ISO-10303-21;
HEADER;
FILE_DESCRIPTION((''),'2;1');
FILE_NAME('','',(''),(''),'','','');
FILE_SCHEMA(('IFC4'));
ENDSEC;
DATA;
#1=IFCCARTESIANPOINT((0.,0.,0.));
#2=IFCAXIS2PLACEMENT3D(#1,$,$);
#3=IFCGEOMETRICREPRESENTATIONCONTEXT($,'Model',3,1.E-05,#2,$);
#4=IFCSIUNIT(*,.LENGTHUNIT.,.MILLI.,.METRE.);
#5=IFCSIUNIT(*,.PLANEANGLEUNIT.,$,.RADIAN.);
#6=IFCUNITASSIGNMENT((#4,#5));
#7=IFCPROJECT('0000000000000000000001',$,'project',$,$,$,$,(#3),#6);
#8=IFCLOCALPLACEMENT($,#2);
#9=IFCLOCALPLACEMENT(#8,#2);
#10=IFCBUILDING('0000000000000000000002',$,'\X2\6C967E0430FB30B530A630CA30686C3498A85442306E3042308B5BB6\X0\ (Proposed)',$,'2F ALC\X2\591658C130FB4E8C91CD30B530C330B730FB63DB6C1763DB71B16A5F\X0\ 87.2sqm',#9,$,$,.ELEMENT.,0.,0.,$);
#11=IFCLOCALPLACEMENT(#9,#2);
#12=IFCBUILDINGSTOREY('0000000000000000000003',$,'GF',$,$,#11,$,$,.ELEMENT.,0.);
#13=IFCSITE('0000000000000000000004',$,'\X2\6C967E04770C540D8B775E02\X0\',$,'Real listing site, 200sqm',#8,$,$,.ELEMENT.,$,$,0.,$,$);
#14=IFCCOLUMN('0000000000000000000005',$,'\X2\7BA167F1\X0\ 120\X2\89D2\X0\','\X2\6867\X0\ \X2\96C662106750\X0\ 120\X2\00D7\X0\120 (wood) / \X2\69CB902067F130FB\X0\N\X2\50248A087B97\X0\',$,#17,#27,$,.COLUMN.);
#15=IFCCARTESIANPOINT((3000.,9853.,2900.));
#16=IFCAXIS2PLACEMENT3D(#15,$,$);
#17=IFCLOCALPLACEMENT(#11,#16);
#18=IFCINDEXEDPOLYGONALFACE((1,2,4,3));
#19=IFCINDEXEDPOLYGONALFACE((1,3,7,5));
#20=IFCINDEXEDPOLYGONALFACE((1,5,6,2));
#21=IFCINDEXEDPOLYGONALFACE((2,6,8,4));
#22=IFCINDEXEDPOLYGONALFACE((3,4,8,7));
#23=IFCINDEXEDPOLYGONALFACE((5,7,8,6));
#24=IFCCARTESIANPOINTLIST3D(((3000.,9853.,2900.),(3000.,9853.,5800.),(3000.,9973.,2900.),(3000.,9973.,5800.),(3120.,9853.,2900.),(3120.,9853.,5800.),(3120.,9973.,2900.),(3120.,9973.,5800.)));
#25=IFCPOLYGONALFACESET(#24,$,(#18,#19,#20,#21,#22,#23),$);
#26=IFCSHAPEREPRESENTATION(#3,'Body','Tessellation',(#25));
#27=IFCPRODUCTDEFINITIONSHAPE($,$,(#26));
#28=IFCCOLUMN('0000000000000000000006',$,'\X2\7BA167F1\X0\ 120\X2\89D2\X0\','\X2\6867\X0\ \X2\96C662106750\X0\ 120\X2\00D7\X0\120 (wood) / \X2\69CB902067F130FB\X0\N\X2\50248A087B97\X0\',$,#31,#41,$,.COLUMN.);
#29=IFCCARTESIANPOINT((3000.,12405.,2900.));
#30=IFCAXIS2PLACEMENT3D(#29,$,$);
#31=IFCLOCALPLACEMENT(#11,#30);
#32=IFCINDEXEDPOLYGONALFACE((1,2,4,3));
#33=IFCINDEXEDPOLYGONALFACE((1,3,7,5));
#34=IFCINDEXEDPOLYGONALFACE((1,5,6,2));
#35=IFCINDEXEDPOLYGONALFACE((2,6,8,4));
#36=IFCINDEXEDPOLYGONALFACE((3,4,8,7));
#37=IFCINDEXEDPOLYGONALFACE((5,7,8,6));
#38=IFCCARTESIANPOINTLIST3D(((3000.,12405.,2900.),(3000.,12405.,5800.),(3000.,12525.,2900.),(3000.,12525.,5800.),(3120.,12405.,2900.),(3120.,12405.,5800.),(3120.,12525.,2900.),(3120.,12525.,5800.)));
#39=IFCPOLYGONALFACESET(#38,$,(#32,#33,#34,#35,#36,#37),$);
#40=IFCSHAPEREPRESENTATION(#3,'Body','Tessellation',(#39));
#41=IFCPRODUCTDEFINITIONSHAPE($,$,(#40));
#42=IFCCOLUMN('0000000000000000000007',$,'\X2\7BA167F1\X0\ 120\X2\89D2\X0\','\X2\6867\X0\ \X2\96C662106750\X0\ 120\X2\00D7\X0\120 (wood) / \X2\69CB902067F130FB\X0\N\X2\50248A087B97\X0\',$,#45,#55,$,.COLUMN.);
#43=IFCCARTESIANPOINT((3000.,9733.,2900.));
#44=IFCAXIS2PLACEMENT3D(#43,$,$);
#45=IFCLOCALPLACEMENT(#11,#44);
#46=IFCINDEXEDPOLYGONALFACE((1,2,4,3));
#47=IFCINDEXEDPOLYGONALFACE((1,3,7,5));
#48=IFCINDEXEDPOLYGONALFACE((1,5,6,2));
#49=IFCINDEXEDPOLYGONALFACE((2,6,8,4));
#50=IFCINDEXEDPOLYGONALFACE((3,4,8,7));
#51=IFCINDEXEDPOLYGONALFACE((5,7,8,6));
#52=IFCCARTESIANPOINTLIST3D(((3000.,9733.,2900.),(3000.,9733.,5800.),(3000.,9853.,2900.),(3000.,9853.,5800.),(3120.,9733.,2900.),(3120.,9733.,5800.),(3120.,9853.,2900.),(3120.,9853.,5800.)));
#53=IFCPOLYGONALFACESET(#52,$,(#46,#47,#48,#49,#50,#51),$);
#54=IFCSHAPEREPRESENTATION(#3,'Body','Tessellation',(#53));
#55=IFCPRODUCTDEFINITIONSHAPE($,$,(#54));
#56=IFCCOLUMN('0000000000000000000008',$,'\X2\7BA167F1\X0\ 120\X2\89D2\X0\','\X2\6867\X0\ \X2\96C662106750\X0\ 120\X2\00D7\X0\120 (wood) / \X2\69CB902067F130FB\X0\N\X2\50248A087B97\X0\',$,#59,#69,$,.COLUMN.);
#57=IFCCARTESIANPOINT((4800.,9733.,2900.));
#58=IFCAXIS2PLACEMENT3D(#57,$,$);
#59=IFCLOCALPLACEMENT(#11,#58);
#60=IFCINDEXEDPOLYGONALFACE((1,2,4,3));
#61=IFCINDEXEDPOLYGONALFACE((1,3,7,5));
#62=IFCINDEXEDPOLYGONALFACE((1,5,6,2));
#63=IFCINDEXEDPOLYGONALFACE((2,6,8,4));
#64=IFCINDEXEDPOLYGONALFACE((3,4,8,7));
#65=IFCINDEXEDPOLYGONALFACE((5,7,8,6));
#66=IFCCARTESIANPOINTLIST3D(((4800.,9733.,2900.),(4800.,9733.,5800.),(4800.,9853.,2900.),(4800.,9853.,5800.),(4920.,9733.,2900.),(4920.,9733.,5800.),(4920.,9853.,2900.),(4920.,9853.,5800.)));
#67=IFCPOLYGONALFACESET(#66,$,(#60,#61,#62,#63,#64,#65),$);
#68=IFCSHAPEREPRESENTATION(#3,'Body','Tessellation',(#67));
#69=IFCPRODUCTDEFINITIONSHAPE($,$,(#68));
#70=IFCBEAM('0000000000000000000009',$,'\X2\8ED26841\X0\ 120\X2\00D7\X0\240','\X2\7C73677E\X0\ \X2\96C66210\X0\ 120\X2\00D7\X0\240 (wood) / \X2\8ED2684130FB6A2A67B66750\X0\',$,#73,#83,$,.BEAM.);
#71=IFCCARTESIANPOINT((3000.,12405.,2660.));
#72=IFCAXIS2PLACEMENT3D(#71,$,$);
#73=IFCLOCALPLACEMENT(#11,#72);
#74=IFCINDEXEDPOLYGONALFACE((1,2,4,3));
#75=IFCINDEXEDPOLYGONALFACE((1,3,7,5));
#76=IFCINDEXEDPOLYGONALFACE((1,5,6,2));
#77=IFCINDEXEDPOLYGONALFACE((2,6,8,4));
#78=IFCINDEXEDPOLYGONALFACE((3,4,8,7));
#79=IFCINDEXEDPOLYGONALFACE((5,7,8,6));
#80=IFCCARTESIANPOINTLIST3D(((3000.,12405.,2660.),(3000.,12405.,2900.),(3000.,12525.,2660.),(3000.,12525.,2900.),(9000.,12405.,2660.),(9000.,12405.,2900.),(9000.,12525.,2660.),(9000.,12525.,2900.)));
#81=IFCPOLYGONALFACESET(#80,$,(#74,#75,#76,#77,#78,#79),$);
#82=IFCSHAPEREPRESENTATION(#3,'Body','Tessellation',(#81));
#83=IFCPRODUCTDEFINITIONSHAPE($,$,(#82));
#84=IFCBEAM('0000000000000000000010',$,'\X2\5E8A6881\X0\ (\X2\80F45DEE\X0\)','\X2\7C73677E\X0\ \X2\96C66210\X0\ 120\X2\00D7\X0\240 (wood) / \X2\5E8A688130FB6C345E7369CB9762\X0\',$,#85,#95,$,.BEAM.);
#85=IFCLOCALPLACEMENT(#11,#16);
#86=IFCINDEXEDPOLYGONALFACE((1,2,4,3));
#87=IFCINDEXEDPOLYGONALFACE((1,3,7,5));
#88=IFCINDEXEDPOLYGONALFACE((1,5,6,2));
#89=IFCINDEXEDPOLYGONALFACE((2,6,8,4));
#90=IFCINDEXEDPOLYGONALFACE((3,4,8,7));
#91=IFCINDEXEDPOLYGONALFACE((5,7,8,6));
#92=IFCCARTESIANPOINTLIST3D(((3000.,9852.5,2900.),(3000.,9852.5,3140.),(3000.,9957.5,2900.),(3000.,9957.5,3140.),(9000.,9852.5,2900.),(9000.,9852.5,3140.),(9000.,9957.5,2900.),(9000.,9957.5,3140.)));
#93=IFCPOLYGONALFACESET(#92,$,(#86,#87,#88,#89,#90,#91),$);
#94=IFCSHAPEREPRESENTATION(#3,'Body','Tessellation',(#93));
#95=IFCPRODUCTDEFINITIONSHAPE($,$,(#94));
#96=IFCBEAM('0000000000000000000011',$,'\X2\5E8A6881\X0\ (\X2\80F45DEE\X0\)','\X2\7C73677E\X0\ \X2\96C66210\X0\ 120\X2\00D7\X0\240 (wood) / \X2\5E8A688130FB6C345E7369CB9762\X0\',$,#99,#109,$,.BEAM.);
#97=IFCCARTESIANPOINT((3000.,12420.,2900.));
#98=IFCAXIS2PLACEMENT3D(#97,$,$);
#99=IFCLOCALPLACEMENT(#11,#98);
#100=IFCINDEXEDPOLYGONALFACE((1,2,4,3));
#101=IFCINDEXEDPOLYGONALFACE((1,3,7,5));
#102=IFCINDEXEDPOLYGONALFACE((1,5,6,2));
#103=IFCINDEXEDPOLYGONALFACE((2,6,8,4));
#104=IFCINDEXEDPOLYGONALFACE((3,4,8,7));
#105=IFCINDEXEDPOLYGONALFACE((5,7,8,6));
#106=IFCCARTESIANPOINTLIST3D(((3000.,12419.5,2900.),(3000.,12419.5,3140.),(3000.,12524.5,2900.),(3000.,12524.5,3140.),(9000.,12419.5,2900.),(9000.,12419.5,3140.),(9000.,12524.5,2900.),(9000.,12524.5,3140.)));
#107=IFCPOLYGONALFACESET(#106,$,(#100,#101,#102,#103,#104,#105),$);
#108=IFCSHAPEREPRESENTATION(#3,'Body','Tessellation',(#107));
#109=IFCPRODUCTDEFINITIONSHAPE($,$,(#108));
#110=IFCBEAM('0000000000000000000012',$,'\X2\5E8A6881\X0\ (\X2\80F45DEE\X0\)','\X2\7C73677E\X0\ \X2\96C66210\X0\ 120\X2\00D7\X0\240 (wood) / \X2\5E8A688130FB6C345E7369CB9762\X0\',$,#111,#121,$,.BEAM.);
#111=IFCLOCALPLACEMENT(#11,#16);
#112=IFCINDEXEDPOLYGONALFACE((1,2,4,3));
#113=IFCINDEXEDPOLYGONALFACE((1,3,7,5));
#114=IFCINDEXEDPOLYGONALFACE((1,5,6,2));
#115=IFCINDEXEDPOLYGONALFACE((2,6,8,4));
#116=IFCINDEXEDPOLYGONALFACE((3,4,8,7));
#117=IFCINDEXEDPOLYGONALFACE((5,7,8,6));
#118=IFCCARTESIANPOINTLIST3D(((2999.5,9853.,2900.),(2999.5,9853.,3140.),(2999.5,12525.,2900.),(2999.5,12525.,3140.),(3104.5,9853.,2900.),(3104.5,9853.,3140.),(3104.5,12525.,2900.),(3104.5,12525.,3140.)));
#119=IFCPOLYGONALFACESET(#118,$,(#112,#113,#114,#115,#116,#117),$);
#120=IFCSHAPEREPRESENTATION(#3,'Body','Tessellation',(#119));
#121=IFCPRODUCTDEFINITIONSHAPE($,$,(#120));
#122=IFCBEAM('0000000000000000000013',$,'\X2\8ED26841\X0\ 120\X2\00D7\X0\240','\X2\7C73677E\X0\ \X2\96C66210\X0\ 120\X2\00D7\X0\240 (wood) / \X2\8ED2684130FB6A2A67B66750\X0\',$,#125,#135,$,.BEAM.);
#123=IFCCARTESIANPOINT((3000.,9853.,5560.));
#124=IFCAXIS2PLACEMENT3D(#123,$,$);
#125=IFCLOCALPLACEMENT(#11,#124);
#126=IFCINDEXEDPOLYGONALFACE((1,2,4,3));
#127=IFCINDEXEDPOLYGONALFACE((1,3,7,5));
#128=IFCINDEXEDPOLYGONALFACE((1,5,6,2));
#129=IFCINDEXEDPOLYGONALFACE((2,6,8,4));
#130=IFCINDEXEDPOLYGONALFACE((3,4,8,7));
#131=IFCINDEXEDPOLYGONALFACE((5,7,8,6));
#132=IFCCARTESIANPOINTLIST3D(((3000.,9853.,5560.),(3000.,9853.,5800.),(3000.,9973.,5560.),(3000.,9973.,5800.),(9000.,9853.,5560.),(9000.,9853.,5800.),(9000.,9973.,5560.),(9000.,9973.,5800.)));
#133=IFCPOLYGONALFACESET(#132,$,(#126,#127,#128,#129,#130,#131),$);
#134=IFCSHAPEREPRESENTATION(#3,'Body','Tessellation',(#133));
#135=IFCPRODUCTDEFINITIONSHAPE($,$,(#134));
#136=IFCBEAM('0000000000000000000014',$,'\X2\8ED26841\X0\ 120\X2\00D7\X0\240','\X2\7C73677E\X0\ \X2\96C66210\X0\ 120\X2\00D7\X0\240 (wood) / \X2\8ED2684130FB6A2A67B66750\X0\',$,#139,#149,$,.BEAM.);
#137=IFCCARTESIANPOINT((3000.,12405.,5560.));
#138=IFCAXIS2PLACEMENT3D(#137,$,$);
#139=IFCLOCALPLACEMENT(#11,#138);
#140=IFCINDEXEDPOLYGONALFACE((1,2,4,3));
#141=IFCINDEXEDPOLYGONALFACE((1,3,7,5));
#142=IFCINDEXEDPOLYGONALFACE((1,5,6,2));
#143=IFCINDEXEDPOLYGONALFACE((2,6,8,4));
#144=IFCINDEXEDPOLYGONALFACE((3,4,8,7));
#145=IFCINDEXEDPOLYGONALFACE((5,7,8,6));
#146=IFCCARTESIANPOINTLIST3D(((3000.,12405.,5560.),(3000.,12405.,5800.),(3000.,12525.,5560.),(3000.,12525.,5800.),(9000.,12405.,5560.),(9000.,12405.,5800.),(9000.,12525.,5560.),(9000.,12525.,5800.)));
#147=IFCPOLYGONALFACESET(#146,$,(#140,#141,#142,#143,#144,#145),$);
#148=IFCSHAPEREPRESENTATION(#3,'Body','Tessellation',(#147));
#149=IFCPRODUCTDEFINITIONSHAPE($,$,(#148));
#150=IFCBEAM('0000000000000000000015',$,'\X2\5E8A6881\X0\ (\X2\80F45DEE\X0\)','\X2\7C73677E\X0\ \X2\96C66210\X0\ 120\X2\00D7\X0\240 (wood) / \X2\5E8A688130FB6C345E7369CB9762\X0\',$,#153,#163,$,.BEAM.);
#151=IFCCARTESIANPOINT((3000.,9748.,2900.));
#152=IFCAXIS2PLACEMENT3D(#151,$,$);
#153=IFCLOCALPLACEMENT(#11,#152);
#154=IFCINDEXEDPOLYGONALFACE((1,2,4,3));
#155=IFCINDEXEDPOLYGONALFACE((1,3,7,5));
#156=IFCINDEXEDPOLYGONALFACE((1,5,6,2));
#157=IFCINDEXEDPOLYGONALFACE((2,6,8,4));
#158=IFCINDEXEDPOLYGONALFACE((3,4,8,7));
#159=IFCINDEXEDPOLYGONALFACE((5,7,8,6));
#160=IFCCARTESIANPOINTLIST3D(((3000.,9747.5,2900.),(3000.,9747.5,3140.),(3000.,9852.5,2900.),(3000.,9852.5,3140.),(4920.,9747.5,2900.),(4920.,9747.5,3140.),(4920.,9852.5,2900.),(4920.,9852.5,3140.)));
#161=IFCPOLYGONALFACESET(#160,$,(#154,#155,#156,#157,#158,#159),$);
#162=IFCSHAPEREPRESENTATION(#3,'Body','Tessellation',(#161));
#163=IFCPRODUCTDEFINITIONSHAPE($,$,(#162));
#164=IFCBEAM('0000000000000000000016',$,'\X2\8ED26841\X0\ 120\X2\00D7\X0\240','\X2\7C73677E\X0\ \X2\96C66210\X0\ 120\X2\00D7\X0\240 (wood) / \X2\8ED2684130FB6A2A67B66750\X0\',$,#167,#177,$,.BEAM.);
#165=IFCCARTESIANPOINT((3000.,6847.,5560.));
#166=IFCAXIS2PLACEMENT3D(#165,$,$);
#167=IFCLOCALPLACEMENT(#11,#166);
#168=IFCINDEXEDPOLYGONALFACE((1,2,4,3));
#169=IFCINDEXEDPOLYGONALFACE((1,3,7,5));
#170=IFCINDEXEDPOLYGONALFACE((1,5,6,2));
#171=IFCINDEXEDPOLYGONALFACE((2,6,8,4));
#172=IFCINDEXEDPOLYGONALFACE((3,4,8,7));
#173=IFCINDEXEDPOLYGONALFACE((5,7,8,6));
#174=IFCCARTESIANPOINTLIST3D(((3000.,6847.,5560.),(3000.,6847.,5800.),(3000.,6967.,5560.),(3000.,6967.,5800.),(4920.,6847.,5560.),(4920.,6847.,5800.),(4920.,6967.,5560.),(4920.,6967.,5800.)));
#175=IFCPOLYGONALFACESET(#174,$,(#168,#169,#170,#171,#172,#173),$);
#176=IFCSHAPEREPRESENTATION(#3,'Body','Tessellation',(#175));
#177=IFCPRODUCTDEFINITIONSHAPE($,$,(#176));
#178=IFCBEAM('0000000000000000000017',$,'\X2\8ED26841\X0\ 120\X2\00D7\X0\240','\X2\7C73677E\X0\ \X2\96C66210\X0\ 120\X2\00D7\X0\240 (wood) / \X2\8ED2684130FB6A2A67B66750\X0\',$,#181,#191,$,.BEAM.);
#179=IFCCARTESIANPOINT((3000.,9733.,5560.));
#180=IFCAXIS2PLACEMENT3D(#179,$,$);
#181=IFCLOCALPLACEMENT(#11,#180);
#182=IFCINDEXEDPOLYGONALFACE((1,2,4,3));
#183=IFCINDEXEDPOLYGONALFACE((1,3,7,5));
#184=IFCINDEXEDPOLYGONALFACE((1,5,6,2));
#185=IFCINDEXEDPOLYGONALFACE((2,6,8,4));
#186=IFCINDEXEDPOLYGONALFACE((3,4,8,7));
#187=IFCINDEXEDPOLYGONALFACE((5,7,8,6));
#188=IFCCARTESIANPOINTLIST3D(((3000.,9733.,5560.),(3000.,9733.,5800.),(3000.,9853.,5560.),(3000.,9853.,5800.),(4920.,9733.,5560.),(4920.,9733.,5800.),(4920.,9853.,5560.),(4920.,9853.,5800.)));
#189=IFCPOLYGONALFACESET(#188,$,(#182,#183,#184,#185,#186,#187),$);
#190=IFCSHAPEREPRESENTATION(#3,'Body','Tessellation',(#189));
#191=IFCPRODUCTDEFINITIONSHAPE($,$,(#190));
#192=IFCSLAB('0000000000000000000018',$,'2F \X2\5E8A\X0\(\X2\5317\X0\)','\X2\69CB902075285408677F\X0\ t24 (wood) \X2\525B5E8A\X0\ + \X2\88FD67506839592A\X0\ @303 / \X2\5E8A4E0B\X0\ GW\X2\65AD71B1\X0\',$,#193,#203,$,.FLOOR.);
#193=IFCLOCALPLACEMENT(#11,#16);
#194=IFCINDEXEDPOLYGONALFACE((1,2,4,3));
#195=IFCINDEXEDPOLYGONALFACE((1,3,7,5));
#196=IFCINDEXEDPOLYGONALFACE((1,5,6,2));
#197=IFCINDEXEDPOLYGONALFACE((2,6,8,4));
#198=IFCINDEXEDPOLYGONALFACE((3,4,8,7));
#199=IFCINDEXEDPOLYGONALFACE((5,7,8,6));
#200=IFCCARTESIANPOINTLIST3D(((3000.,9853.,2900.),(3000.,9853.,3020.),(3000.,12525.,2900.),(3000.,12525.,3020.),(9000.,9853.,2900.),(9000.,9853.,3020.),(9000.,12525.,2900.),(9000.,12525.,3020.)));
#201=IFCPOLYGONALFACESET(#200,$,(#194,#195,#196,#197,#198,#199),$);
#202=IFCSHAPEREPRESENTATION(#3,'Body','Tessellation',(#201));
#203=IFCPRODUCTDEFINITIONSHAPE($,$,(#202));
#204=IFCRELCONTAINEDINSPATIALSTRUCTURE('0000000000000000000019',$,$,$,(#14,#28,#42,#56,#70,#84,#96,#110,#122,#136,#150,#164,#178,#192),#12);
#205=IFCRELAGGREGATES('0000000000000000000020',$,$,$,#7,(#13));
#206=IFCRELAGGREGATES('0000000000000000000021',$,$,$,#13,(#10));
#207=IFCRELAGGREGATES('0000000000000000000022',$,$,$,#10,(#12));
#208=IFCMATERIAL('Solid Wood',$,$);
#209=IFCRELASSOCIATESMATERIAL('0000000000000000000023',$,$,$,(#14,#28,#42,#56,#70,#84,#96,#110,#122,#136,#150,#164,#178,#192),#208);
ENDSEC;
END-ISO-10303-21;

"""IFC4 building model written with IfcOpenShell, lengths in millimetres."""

from ifc_helpers import new_model, si_unit, frame, frame_2d, origin, place, context, project, spatial, rectangle, extrude, material, element, save


model = new_model("IFC4")

# Units and contexts
model_context = context("Model", 3, precision=1e-05, world=origin())
ifc_project = project(units=[si_unit("LENGTHUNIT", "METRE", prefix="MILLI"), si_unit("PLANEANGLEUNIT", "RADIAN")], contexts=[model_context])

# Site, building, storey
site_placement = place(None, origin())
site = spatial("IfcSite", under=ifc_project, at=site_placement, Name="沖縄県名護市", ObjectType="Real listing site, 200sqm", CompositionType="ELEMENT", RefElevation=0.0)
building_placement = place(site_placement, origin())
building = spatial("IfcBuilding", under=site, at=building_placement, Name="沖縄・サウナと水風呂のある家 (Proposed)", ObjectType="2F ALC外壁・二重サッシ・換気換熱機 87.2sqm", CompositionType="ELEMENT", ElevationOfRefHeight=0.0, ElevationOfTerrain=0.0)
storey_placement = place(building_placement, origin())
storey = spatial("IfcBuildingStorey", under=building, at=storey_placement, Name="GF", CompositionType="ELEMENT", Elevation=0.0)

# Columns
ifc_material_1 = material(Name="Solid Wood")
column_1_placement = place(storey_placement, frame((3000.0, 9853.0, 2900.0)))
element("IfcColumn", 1, at=column_1_placement, inside=storey, material=ifc_material_1, Name="管柱 120角", Description="桧 集成材 120×120 (wood) / 構造柱・N値計算", PredefinedType="COLUMN", context=model_context, shape_type="SweptSolid", body=[
    extrude(rectangle(XDim=120.0, YDim=120.0, at=frame_2d((60.0, 60.0))), frame((3000.0, 9853.0, 2900.0)), (0.0, 0.0, 1.0), 2900.0),
])
column_2_placement = place(storey_placement, frame((3000.0, 12405.0, 2900.0)))
element("IfcColumn", 2, at=column_2_placement, inside=storey, material=ifc_material_1, Name="管柱 120角", Description="桧 集成材 120×120 (wood) / 構造柱・N値計算", PredefinedType="COLUMN", context=model_context, shape_type="SweptSolid", body=[
    extrude(rectangle(XDim=120.0, YDim=120.0, at=frame_2d((60.0, 60.0))), frame((3000.0, 12405.0, 2900.0)), (0.0, 0.0, 1.0), 2900.0),
])
column_3_placement = place(storey_placement, frame((3000.0, 9733.0, 2900.0)))
element("IfcColumn", 3, at=column_3_placement, inside=storey, material=ifc_material_1, Name="管柱 120角", Description="桧 集成材 120×120 (wood) / 構造柱・N値計算", PredefinedType="COLUMN", context=model_context, shape_type="SweptSolid", body=[
    extrude(rectangle(XDim=120.0, YDim=120.0, at=frame_2d((60.0, 60.0))), frame((3000.0, 9733.0, 2900.0)), (0.0, 0.0, 1.0), 2900.0),
])
column_4_placement = place(storey_placement, frame((4800.0, 9733.0, 2900.0)))
element("IfcColumn", 4, at=column_4_placement, inside=storey, material=ifc_material_1, Name="管柱 120角", Description="桧 集成材 120×120 (wood) / 構造柱・N値計算", PredefinedType="COLUMN", context=model_context, shape_type="SweptSolid", body=[
    extrude(rectangle(XDim=120.0, YDim=120.0, at=frame_2d((60.0, 60.0))), frame((4800.0, 9733.0, 2900.0)), (0.0, 0.0, 1.0), 2900.0),
])

# Beams
beam_1_placement = place(storey_placement, frame((3000.0, 12405.0, 2660.0)))
element("IfcBeam", 5, at=beam_1_placement, inside=storey, material=ifc_material_1, Name="軒桁 120×240", Description="米松 集成 120×240 (wood) / 軒桁・横架材", PredefinedType="BEAM", context=model_context, shape_type="SweptSolid", body=[
    extrude(rectangle(XDim=6000.0, YDim=120.0, at=frame_2d((3000.0, 60.0))), frame((3000.0, 12405.0, 2660.0)), (0.0, 0.0, 1.0), 240.0),
])
beam_2_placement = place(storey_placement, frame((3000.0, 9853.0, 2900.0)))
element("IfcBeam", 6, at=beam_2_placement, inside=storey, material=ifc_material_1, Name="床梁 (胴差)", Description="米松 集成 120×240 (wood) / 床梁・水平構面", PredefinedType="BEAM", context=model_context, shape_type="SweptSolid", body=[
    extrude(rectangle(XDim=6000.0, YDim=105.0, at=frame_2d((3000.0, 52.0))), frame((3000.0, 9853.0, 2900.0)), (0.0, 0.0, 1.0), 240.0),
])
beam_3_placement = place(storey_placement, frame((3000.0, 12420.0, 2900.0)))
element("IfcBeam", 7, at=beam_3_placement, inside=storey, material=ifc_material_1, Name="床梁 (胴差)", Description="米松 集成 120×240 (wood) / 床梁・水平構面", PredefinedType="BEAM", context=model_context, shape_type="SweptSolid", body=[
    extrude(rectangle(XDim=6000.0, YDim=105.0, at=frame_2d((3000.0, 52.0))), frame((3000.0, 12420.0, 2900.0)), (0.0, 0.0, 1.0), 240.0),
])
beam_4_placement = place(storey_placement, frame((3000.0, 9853.0, 2900.0)))
element("IfcBeam", 8, at=beam_4_placement, inside=storey, material=ifc_material_1, Name="床梁 (胴差)", Description="米松 集成 120×240 (wood) / 床梁・水平構面", PredefinedType="BEAM", context=model_context, shape_type="SweptSolid", body=[
    extrude(rectangle(XDim=105.0, YDim=2672.0, at=frame_2d((52.0, 1336.0))), frame((3000.0, 9853.0, 2900.0)), (0.0, 0.0, 1.0), 240.0),
])
beam_5_placement = place(storey_placement, frame((3000.0, 9853.0, 5560.0)))
element("IfcBeam", 9, at=beam_5_placement, inside=storey, material=ifc_material_1, Name="軒桁 120×240", Description="米松 集成 120×240 (wood) / 軒桁・横架材", PredefinedType="BEAM", context=model_context, shape_type="SweptSolid", body=[
    extrude(rectangle(XDim=6000.0, YDim=120.0, at=frame_2d((3000.0, 60.0))), frame((3000.0, 9853.0, 5560.0)), (0.0, 0.0, 1.0), 240.0),
])
beam_6_placement = place(storey_placement, frame((3000.0, 12405.0, 5560.0)))
element("IfcBeam", 10, at=beam_6_placement, inside=storey, material=ifc_material_1, Name="軒桁 120×240", Description="米松 集成 120×240 (wood) / 軒桁・横架材", PredefinedType="BEAM", context=model_context, shape_type="SweptSolid", body=[
    extrude(rectangle(XDim=6000.0, YDim=120.0, at=frame_2d((3000.0, 60.0))), frame((3000.0, 12405.0, 5560.0)), (0.0, 0.0, 1.0), 240.0),
])
beam_7_placement = place(storey_placement, frame((3000.0, 9748.0, 2900.0)))
element("IfcBeam", 11, at=beam_7_placement, inside=storey, material=ifc_material_1, Name="床梁 (胴差)", Description="米松 集成 120×240 (wood) / 床梁・水平構面", PredefinedType="BEAM", context=model_context, shape_type="SweptSolid", body=[
    extrude(rectangle(XDim=1920.0, YDim=105.0, at=frame_2d((960.0, 52.0))), frame((3000.0, 9748.0, 2900.0)), (0.0, 0.0, 1.0), 240.0),
])
beam_8_placement = place(storey_placement, frame((3000.0, 6847.0, 5560.0)))
element("IfcBeam", 12, at=beam_8_placement, inside=storey, material=ifc_material_1, Name="軒桁 120×240", Description="米松 集成 120×240 (wood) / 軒桁・横架材", PredefinedType="BEAM", context=model_context, shape_type="SweptSolid", body=[
    extrude(rectangle(XDim=1920.0, YDim=120.0, at=frame_2d((960.0, 60.0))), frame((3000.0, 6847.0, 5560.0)), (0.0, 0.0, 1.0), 240.0),
])
beam_9_placement = place(storey_placement, frame((3000.0, 9733.0, 5560.0)))
element("IfcBeam", 13, at=beam_9_placement, inside=storey, material=ifc_material_1, Name="軒桁 120×240", Description="米松 集成 120×240 (wood) / 軒桁・横架材", PredefinedType="BEAM", context=model_context, shape_type="SweptSolid", body=[
    extrude(rectangle(XDim=1920.0, YDim=120.0, at=frame_2d((960.0, 60.0))), frame((3000.0, 9733.0, 5560.0)), (0.0, 0.0, 1.0), 240.0),
])

# Slab
slab_placement = place(storey_placement, frame((3000.0, 9853.0, 2900.0)))
element("IfcSlab", 14, at=slab_placement, inside=storey, material=ifc_material_1, Name="2F 床(北)", Description="構造用合板 t24 (wood) 剛床 + 製材根太 @303 / 床下 GW断熱", PredefinedType="FLOOR", context=model_context, shape_type="SweptSolid", body=[
    extrude(rectangle(XDim=6000.0, YDim=2672.0, at=frame_2d((3000.0, 1336.0))), frame((3000.0, 9853.0, 2900.0)), (0.0, 0.0, 1.0), 120.0),
])

save(model, "model.ifc")
